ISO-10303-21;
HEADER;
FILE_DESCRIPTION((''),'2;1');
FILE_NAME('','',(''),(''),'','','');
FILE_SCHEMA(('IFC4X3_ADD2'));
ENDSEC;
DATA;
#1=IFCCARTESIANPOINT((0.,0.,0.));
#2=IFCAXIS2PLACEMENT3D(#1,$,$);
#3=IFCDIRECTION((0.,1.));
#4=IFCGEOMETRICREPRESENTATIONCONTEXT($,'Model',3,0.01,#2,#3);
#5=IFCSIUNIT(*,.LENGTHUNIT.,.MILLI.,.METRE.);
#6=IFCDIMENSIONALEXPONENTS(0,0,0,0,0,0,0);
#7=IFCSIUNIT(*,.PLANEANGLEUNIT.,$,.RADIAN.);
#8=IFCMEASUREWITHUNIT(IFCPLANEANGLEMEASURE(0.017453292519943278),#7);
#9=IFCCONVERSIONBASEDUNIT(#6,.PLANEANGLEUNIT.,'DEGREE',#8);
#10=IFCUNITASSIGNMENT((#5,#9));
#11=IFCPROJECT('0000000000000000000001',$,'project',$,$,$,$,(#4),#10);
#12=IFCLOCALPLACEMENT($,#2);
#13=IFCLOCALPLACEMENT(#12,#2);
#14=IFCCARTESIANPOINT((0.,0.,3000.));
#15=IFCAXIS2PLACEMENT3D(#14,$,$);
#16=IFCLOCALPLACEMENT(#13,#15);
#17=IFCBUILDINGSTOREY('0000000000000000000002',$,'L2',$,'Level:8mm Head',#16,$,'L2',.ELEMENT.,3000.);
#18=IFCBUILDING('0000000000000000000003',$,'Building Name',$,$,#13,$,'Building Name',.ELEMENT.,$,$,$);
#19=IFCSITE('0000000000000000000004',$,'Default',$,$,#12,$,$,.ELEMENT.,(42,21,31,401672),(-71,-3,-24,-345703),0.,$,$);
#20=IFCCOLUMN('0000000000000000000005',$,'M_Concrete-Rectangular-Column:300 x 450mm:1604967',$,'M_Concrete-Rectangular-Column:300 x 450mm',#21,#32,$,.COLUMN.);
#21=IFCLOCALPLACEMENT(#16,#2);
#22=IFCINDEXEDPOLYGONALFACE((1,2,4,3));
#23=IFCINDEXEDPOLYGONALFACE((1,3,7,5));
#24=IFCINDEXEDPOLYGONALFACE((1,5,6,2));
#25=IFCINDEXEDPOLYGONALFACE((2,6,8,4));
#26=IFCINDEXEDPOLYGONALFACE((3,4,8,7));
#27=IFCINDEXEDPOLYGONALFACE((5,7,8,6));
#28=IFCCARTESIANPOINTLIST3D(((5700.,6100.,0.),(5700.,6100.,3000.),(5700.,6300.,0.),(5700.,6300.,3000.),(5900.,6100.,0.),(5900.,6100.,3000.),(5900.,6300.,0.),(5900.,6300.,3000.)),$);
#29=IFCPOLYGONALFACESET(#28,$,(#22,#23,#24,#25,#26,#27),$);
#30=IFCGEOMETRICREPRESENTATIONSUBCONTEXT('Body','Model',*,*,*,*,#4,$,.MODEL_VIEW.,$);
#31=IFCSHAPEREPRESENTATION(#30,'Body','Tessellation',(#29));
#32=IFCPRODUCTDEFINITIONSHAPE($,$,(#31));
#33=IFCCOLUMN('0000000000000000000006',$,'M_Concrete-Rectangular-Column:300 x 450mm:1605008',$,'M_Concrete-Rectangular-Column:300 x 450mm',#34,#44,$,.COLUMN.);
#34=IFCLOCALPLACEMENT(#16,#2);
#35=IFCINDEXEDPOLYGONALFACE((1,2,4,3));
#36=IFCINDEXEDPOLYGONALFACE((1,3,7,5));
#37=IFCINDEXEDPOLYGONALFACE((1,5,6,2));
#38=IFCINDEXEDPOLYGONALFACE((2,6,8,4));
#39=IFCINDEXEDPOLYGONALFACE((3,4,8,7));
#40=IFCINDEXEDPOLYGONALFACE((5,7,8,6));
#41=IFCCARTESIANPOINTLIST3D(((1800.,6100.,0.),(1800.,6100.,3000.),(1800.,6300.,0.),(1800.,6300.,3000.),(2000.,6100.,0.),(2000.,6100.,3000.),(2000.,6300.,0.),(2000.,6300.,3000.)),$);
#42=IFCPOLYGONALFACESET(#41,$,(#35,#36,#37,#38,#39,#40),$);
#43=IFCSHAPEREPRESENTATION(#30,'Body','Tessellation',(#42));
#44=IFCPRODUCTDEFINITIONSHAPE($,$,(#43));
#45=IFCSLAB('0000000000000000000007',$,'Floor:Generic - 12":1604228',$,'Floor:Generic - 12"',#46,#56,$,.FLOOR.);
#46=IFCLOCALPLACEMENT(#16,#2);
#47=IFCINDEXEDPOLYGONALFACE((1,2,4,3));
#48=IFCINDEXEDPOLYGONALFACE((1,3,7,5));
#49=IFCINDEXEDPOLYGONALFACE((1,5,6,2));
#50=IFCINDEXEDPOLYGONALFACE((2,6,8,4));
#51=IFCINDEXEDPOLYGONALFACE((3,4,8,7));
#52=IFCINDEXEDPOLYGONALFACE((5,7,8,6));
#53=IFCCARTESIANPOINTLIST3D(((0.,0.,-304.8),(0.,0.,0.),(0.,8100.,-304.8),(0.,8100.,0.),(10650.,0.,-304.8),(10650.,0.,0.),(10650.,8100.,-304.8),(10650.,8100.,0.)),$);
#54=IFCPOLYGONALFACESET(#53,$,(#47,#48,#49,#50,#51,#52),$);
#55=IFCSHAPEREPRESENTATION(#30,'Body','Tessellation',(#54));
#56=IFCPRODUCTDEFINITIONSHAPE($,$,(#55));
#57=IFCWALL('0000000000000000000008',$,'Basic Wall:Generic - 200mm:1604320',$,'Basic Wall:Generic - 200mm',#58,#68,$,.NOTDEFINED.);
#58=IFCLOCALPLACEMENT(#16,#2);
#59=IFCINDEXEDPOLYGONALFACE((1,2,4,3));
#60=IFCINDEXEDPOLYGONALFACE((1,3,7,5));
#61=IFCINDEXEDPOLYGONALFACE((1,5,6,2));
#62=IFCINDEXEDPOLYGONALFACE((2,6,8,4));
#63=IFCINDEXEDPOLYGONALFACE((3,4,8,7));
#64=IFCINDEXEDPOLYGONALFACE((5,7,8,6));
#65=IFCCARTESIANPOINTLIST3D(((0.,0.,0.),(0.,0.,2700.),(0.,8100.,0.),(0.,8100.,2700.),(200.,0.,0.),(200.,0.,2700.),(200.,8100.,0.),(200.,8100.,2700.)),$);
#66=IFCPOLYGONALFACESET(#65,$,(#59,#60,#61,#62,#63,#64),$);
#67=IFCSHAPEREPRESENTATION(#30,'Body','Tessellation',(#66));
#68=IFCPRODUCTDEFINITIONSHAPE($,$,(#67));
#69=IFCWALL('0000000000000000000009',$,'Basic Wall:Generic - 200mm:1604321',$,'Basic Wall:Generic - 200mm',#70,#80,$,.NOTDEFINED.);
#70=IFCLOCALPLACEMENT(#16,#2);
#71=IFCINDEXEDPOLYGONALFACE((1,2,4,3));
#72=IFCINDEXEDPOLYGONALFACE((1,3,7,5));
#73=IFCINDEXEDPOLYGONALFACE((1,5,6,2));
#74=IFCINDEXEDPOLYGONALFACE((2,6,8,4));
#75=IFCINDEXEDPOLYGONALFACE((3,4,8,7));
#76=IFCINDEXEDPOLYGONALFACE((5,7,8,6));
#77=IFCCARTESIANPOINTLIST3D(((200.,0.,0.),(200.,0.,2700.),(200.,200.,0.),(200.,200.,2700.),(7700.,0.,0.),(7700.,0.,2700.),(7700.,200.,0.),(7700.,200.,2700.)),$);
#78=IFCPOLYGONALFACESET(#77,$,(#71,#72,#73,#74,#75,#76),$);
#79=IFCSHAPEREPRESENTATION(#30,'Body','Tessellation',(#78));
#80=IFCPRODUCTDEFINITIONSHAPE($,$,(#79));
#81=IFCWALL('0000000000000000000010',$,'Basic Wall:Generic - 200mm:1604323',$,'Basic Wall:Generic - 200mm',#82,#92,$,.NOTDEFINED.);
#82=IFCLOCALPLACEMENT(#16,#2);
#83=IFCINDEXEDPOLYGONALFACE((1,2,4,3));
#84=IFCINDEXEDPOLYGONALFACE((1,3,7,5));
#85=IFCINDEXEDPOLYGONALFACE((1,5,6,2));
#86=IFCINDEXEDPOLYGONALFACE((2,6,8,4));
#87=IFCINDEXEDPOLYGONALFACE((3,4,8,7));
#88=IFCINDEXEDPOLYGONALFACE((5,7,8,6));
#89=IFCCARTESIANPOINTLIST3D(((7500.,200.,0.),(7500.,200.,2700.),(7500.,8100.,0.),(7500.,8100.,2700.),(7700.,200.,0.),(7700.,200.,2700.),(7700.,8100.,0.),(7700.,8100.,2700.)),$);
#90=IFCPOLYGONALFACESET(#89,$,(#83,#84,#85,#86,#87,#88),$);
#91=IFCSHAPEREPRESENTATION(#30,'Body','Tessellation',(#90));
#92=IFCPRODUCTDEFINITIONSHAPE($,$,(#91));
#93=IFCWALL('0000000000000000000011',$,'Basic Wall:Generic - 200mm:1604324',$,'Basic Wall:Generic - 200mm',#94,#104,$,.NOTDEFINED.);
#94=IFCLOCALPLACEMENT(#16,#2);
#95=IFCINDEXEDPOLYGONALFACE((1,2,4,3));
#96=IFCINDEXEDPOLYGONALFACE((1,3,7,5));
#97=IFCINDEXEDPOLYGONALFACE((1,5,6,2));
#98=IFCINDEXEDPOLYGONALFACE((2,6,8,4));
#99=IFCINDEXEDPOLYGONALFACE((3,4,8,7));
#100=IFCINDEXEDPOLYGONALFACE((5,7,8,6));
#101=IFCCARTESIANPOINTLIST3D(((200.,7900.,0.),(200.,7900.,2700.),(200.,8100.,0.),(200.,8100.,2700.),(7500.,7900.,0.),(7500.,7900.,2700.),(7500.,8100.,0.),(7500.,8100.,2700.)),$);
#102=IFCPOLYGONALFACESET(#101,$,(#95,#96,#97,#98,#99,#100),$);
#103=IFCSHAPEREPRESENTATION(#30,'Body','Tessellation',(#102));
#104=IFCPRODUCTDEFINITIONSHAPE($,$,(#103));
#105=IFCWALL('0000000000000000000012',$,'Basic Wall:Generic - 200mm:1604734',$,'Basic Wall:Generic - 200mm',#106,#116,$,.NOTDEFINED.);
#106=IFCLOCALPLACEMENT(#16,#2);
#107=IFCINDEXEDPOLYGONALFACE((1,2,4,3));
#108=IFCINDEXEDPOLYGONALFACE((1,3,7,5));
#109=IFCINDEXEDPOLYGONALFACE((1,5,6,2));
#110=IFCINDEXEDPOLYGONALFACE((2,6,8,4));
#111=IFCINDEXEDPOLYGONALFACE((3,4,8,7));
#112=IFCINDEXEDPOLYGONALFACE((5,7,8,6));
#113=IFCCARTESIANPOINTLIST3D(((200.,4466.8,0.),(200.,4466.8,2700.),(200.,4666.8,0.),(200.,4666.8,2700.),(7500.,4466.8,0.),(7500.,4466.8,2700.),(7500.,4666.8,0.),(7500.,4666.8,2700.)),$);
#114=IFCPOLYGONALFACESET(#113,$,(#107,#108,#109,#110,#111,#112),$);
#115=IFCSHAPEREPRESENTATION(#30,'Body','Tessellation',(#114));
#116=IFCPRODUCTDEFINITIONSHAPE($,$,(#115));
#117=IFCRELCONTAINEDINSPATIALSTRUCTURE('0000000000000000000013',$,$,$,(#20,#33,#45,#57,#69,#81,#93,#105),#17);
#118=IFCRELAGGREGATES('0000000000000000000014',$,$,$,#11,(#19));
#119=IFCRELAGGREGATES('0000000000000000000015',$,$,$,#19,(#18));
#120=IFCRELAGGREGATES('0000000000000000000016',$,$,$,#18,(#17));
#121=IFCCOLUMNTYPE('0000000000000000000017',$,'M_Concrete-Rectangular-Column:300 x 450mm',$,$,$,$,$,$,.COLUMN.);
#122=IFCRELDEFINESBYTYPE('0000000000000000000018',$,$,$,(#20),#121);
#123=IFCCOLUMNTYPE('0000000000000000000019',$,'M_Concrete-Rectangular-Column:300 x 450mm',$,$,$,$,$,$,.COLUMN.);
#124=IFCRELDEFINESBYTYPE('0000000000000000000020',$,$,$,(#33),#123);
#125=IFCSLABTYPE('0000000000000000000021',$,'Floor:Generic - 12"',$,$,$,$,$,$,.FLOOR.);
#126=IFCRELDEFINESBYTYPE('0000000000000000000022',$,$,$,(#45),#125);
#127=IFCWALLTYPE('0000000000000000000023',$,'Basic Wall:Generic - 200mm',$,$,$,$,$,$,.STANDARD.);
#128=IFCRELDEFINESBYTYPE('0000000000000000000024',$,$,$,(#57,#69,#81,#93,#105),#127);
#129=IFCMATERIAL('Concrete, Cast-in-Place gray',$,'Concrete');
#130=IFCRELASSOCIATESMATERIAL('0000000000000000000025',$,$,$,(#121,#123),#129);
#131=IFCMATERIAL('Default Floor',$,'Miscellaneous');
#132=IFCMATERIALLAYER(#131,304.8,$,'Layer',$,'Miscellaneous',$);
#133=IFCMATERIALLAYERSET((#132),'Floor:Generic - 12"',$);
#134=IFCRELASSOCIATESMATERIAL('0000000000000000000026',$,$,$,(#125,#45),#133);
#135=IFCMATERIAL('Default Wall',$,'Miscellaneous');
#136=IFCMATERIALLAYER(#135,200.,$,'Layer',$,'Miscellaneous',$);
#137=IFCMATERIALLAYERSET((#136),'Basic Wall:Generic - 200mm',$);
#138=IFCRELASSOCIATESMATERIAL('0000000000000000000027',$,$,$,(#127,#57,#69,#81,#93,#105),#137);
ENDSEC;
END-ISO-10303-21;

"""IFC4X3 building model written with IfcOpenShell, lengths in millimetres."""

from ifc_helpers import new_model, entity, si_unit, converted_unit, direction, frame, frame_2d, origin, origin_2d_with_axis, place, context, subcontext, project, spatial, rectangle, extrude, source, transform, mapped, material, layer, layer_set, layer_usage, material_profile, profile_set, type_object, type_shapes, element, save


model = new_model("IFC4X3")

# Units and contexts
model_context = context("Model", 3, precision=0.01, world=origin(), true_north=direction((0.0, 1.0)))
body_context = subcontext(model_context, "Body", "Model", "MODEL_VIEW")
ifc_project = project(units=[si_unit("LENGTHUNIT", "METRE", prefix="MILLI"), converted_unit("PLANEANGLEUNIT", "DEGREE", entity("IfcPlaneAngleMeasure", 0.017453292519943278), si_unit("PLANEANGLEUNIT", "RADIAN"), dimensions=[0, 0, 0, 0, 0, 0, 0])], contexts=[model_context])

# Site, building, storey
site_placement = place(None, origin())
site = spatial("IfcSite", under=ifc_project, at=site_placement, Name="Default", CompositionType="ELEMENT", RefLatitude=(42, 21, 31, 401672), RefLongitude=(-71, -3, -24, -345703), RefElevation=0.0)
building_placement = place(site_placement, origin())
building = spatial("IfcBuilding", under=site, at=building_placement, Name="Building Name", LongName="Building Name", CompositionType="ELEMENT")
storey_placement = place(building_placement, frame((0.0, 0.0, 3000.0)))
storey = spatial("IfcBuildingStorey", under=building, at=storey_placement, Name="L2", ObjectType="Level:8mm Head", LongName="L2", CompositionType="ELEMENT", Elevation=3000.0)

# Columns
ifc_material_1 = material(Name="Concrete, Cast-in-Place gray", Category="Concrete")
ifc_material_profile = material_profile(ifc_material_1, rectangle(XDim=200.0, YDim=200.0, at=frame_2d((0.0, 0.0), x_axis=(1.0, 0.0))), Name="300 x 450mm")
ifc_profile_set = profile_set([ifc_material_profile], Name="300 x 450mm")
column_type_1 = type_object("IfcColumnType", Name="M_Concrete-Rectangular-Column:300 x 450mm", PredefinedType="COLUMN", material=ifc_profile_set)
shared_shape_1 = source(origin(), body_context, "Body", "SweptSolid", [
    extrude(rectangle(XDim=200.0, YDim=200.0, at=frame_2d((0.0, 0.0), x_axis=(1.0, 0.0))), frame((5800.0, 6200.0, 3000.0), z_axis=(0.0, 0.0, 1.0), x_axis=(-1.0, 0.0, 0.0)), (0.0, 0.0, 1.0), 3000.0),
])
type_shapes(column_type_1, [shared_shape_1])
column_1_placement = place(storey_placement, frame((0.0, 0.0, -3000.0)))
element("IfcColumn", 1, at=column_1_placement, inside=storey, type_object=column_type_1, Name="M_Concrete-Rectangular-Column:300 x 450mm:1604967", ObjectType="M_Concrete-Rectangular-Column:300 x 450mm", PredefinedType="COLUMN", context=body_context, shape_type="MappedRepresentation", body=[
    mapped(shared_shape_1, transform((0.0, 0.0, 0.0), scale=1.0)),
])
column_type_2 = type_object("IfcColumnType", Name="M_Concrete-Rectangular-Column:300 x 450mm", PredefinedType="COLUMN", material=ifc_profile_set)
shared_shape_2 = source(origin(), body_context, "Body", "SweptSolid", [
    extrude(rectangle(XDim=200.0, YDim=200.0, at=frame_2d((0.0, 0.0), x_axis=(1.0, 0.0))), frame((1900.0, 6200.0, 3000.0), z_axis=(0.0, 0.0, 1.0), x_axis=(-1.0, 0.0, 0.0)), (0.0, 0.0, 1.0), 3000.0),
])
type_shapes(column_type_2, [shared_shape_2])
column_2_placement = place(storey_placement, frame((0.0, 0.0, -3000.0)))
element("IfcColumn", 2, at=column_2_placement, inside=storey, type_object=column_type_2, Name="M_Concrete-Rectangular-Column:300 x 450mm:1605008", ObjectType="M_Concrete-Rectangular-Column:300 x 450mm", PredefinedType="COLUMN", context=body_context, shape_type="MappedRepresentation", body=[
    mapped(shared_shape_2, transform((0.0, 0.0, 0.0), scale=1.0)),
])

# Slab
ifc_material_2 = material(Name="Default Floor", Category="Miscellaneous")
ifc_layer_1 = layer(ifc_material_2, 304.8, Name="Layer", Category="Miscellaneous")
ifc_layer_set_1 = layer_set([ifc_layer_1], Name="Floor:Generic - 12\"")
ifc_layer_usage = layer_usage(ifc_layer_set_1, "AXIS3", "POSITIVE", 0.0)
slab_type = type_object("IfcSlabType", Name="Floor:Generic - 12\"", PredefinedType="FLOOR", material=ifc_layer_set_1)
slab_placement = place(storey_placement, origin())
element("IfcSlab", 3, at=slab_placement, inside=storey, type_object=slab_type, material=ifc_layer_usage, Name="Floor:Generic - 12\":1604228", ObjectType="Floor:Generic - 12\"", PredefinedType="FLOOR", context=body_context, shape_type="SweptSolid", body=[
    extrude(rectangle(XDim=8100.0, YDim=10650.0, at=origin_2d_with_axis()), frame((5325.0, 4050.0, 0.0), z_axis=(0.0, 0.0, -1.0), x_axis=(0.0, 1.0, 0.0)), (0.0, 0.0, 1.0), 304.8),
])

# Walls
ifc_material_3 = material(Name="Default Wall", Category="Miscellaneous")
ifc_layer_2 = layer(ifc_material_3, 200.0, Name="Layer", Category="Miscellaneous")
ifc_layer_set_2 = layer_set([ifc_layer_2], Name="Basic Wall:Generic - 200mm")
wall_type = type_object("IfcWallType", Name="Basic Wall:Generic - 200mm", PredefinedType="STANDARD", material=ifc_layer_set_2)
wall_1_placement = place(storey_placement, frame((100.0, 8100.0, 0.0), z_axis=(0.0, 0.0, 1.0), x_axis=(0.0, -1.0, 0.0)))
element("IfcWall", 4, at=wall_1_placement, inside=storey, type_object=wall_type, material=ifc_layer_set_2, Name="Basic Wall:Generic - 200mm:1604320", ObjectType="Basic Wall:Generic - 200mm", PredefinedType="NOTDEFINED", context=body_context, shape_type="SweptSolid", body=[
    extrude(rectangle(XDim=8100.0, YDim=200.0, at=frame_2d((4050.0, 0.0), x_axis=(-1.0, 0.0))), origin(), (0.0, 0.0, 1.0), 2700.0),
])
wall_2_placement = place(storey_placement, frame((200.0, 100.0, 0.0)))
element("IfcWall", 5, at=wall_2_placement, inside=storey, type_object=wall_type, material=ifc_layer_set_2, Name="Basic Wall:Generic - 200mm:1604321", ObjectType="Basic Wall:Generic - 200mm", PredefinedType="NOTDEFINED", context=body_context, shape_type="SweptSolid", body=[
    extrude(rectangle(XDim=7500.0, YDim=200.0, at=frame_2d((3750.0, 0.0), x_axis=(-1.0, 0.0))), origin(), (0.0, 0.0, 1.0), 2700.0),
])
wall_3_placement = place(storey_placement, frame((7600.0, 200.0, 0.0), z_axis=(0.0, 0.0, 1.0), x_axis=(0.0, 1.0, 0.0)))
element("IfcWall", 6, at=wall_3_placement, inside=storey, type_object=wall_type, material=ifc_layer_set_2, Name="Basic Wall:Generic - 200mm:1604323", ObjectType="Basic Wall:Generic - 200mm", PredefinedType="NOTDEFINED", context=body_context, shape_type="SweptSolid", body=[
    extrude(rectangle(XDim=7900.0, YDim=200.0, at=frame_2d((3950.0, 0.0), x_axis=(-1.0, 0.0))), origin(), (0.0, 0.0, 1.0), 2700.0),
])
wall_4_placement = place(storey_placement, frame((7500.0, 8000.0, 0.0), z_axis=(0.0, 0.0, 1.0), x_axis=(-1.0, 0.0, 0.0)))
element("IfcWall", 7, at=wall_4_placement, inside=storey, type_object=wall_type, material=ifc_layer_set_2, Name="Basic Wall:Generic - 200mm:1604324", ObjectType="Basic Wall:Generic - 200mm", PredefinedType="NOTDEFINED", context=body_context, shape_type="SweptSolid", body=[
    extrude(rectangle(XDim=7300.0, YDim=200.0, at=frame_2d((3650.0, 0.0), x_axis=(-1.0, 0.0))), origin(), (0.0, 0.0, 1.0), 2700.0),
])
wall_5_placement = place(storey_placement, frame((7500.0, 4566.8, 0.0), z_axis=(0.0, 0.0, 1.0), x_axis=(-1.0, 0.0, 0.0)))
element("IfcWall", 8, at=wall_5_placement, inside=storey, type_object=wall_type, material=ifc_layer_set_2, Name="Basic Wall:Generic - 200mm:1604734", ObjectType="Basic Wall:Generic - 200mm", PredefinedType="NOTDEFINED", context=body_context, shape_type="SweptSolid", body=[
    extrude(rectangle(XDim=7300.0, YDim=200.0, at=frame_2d((3650.0, 0.0), x_axis=(-1.0, 0.0))), origin(), (0.0, 0.0, 1.0), 2700.0),
])

save(model, "model.ifc")
